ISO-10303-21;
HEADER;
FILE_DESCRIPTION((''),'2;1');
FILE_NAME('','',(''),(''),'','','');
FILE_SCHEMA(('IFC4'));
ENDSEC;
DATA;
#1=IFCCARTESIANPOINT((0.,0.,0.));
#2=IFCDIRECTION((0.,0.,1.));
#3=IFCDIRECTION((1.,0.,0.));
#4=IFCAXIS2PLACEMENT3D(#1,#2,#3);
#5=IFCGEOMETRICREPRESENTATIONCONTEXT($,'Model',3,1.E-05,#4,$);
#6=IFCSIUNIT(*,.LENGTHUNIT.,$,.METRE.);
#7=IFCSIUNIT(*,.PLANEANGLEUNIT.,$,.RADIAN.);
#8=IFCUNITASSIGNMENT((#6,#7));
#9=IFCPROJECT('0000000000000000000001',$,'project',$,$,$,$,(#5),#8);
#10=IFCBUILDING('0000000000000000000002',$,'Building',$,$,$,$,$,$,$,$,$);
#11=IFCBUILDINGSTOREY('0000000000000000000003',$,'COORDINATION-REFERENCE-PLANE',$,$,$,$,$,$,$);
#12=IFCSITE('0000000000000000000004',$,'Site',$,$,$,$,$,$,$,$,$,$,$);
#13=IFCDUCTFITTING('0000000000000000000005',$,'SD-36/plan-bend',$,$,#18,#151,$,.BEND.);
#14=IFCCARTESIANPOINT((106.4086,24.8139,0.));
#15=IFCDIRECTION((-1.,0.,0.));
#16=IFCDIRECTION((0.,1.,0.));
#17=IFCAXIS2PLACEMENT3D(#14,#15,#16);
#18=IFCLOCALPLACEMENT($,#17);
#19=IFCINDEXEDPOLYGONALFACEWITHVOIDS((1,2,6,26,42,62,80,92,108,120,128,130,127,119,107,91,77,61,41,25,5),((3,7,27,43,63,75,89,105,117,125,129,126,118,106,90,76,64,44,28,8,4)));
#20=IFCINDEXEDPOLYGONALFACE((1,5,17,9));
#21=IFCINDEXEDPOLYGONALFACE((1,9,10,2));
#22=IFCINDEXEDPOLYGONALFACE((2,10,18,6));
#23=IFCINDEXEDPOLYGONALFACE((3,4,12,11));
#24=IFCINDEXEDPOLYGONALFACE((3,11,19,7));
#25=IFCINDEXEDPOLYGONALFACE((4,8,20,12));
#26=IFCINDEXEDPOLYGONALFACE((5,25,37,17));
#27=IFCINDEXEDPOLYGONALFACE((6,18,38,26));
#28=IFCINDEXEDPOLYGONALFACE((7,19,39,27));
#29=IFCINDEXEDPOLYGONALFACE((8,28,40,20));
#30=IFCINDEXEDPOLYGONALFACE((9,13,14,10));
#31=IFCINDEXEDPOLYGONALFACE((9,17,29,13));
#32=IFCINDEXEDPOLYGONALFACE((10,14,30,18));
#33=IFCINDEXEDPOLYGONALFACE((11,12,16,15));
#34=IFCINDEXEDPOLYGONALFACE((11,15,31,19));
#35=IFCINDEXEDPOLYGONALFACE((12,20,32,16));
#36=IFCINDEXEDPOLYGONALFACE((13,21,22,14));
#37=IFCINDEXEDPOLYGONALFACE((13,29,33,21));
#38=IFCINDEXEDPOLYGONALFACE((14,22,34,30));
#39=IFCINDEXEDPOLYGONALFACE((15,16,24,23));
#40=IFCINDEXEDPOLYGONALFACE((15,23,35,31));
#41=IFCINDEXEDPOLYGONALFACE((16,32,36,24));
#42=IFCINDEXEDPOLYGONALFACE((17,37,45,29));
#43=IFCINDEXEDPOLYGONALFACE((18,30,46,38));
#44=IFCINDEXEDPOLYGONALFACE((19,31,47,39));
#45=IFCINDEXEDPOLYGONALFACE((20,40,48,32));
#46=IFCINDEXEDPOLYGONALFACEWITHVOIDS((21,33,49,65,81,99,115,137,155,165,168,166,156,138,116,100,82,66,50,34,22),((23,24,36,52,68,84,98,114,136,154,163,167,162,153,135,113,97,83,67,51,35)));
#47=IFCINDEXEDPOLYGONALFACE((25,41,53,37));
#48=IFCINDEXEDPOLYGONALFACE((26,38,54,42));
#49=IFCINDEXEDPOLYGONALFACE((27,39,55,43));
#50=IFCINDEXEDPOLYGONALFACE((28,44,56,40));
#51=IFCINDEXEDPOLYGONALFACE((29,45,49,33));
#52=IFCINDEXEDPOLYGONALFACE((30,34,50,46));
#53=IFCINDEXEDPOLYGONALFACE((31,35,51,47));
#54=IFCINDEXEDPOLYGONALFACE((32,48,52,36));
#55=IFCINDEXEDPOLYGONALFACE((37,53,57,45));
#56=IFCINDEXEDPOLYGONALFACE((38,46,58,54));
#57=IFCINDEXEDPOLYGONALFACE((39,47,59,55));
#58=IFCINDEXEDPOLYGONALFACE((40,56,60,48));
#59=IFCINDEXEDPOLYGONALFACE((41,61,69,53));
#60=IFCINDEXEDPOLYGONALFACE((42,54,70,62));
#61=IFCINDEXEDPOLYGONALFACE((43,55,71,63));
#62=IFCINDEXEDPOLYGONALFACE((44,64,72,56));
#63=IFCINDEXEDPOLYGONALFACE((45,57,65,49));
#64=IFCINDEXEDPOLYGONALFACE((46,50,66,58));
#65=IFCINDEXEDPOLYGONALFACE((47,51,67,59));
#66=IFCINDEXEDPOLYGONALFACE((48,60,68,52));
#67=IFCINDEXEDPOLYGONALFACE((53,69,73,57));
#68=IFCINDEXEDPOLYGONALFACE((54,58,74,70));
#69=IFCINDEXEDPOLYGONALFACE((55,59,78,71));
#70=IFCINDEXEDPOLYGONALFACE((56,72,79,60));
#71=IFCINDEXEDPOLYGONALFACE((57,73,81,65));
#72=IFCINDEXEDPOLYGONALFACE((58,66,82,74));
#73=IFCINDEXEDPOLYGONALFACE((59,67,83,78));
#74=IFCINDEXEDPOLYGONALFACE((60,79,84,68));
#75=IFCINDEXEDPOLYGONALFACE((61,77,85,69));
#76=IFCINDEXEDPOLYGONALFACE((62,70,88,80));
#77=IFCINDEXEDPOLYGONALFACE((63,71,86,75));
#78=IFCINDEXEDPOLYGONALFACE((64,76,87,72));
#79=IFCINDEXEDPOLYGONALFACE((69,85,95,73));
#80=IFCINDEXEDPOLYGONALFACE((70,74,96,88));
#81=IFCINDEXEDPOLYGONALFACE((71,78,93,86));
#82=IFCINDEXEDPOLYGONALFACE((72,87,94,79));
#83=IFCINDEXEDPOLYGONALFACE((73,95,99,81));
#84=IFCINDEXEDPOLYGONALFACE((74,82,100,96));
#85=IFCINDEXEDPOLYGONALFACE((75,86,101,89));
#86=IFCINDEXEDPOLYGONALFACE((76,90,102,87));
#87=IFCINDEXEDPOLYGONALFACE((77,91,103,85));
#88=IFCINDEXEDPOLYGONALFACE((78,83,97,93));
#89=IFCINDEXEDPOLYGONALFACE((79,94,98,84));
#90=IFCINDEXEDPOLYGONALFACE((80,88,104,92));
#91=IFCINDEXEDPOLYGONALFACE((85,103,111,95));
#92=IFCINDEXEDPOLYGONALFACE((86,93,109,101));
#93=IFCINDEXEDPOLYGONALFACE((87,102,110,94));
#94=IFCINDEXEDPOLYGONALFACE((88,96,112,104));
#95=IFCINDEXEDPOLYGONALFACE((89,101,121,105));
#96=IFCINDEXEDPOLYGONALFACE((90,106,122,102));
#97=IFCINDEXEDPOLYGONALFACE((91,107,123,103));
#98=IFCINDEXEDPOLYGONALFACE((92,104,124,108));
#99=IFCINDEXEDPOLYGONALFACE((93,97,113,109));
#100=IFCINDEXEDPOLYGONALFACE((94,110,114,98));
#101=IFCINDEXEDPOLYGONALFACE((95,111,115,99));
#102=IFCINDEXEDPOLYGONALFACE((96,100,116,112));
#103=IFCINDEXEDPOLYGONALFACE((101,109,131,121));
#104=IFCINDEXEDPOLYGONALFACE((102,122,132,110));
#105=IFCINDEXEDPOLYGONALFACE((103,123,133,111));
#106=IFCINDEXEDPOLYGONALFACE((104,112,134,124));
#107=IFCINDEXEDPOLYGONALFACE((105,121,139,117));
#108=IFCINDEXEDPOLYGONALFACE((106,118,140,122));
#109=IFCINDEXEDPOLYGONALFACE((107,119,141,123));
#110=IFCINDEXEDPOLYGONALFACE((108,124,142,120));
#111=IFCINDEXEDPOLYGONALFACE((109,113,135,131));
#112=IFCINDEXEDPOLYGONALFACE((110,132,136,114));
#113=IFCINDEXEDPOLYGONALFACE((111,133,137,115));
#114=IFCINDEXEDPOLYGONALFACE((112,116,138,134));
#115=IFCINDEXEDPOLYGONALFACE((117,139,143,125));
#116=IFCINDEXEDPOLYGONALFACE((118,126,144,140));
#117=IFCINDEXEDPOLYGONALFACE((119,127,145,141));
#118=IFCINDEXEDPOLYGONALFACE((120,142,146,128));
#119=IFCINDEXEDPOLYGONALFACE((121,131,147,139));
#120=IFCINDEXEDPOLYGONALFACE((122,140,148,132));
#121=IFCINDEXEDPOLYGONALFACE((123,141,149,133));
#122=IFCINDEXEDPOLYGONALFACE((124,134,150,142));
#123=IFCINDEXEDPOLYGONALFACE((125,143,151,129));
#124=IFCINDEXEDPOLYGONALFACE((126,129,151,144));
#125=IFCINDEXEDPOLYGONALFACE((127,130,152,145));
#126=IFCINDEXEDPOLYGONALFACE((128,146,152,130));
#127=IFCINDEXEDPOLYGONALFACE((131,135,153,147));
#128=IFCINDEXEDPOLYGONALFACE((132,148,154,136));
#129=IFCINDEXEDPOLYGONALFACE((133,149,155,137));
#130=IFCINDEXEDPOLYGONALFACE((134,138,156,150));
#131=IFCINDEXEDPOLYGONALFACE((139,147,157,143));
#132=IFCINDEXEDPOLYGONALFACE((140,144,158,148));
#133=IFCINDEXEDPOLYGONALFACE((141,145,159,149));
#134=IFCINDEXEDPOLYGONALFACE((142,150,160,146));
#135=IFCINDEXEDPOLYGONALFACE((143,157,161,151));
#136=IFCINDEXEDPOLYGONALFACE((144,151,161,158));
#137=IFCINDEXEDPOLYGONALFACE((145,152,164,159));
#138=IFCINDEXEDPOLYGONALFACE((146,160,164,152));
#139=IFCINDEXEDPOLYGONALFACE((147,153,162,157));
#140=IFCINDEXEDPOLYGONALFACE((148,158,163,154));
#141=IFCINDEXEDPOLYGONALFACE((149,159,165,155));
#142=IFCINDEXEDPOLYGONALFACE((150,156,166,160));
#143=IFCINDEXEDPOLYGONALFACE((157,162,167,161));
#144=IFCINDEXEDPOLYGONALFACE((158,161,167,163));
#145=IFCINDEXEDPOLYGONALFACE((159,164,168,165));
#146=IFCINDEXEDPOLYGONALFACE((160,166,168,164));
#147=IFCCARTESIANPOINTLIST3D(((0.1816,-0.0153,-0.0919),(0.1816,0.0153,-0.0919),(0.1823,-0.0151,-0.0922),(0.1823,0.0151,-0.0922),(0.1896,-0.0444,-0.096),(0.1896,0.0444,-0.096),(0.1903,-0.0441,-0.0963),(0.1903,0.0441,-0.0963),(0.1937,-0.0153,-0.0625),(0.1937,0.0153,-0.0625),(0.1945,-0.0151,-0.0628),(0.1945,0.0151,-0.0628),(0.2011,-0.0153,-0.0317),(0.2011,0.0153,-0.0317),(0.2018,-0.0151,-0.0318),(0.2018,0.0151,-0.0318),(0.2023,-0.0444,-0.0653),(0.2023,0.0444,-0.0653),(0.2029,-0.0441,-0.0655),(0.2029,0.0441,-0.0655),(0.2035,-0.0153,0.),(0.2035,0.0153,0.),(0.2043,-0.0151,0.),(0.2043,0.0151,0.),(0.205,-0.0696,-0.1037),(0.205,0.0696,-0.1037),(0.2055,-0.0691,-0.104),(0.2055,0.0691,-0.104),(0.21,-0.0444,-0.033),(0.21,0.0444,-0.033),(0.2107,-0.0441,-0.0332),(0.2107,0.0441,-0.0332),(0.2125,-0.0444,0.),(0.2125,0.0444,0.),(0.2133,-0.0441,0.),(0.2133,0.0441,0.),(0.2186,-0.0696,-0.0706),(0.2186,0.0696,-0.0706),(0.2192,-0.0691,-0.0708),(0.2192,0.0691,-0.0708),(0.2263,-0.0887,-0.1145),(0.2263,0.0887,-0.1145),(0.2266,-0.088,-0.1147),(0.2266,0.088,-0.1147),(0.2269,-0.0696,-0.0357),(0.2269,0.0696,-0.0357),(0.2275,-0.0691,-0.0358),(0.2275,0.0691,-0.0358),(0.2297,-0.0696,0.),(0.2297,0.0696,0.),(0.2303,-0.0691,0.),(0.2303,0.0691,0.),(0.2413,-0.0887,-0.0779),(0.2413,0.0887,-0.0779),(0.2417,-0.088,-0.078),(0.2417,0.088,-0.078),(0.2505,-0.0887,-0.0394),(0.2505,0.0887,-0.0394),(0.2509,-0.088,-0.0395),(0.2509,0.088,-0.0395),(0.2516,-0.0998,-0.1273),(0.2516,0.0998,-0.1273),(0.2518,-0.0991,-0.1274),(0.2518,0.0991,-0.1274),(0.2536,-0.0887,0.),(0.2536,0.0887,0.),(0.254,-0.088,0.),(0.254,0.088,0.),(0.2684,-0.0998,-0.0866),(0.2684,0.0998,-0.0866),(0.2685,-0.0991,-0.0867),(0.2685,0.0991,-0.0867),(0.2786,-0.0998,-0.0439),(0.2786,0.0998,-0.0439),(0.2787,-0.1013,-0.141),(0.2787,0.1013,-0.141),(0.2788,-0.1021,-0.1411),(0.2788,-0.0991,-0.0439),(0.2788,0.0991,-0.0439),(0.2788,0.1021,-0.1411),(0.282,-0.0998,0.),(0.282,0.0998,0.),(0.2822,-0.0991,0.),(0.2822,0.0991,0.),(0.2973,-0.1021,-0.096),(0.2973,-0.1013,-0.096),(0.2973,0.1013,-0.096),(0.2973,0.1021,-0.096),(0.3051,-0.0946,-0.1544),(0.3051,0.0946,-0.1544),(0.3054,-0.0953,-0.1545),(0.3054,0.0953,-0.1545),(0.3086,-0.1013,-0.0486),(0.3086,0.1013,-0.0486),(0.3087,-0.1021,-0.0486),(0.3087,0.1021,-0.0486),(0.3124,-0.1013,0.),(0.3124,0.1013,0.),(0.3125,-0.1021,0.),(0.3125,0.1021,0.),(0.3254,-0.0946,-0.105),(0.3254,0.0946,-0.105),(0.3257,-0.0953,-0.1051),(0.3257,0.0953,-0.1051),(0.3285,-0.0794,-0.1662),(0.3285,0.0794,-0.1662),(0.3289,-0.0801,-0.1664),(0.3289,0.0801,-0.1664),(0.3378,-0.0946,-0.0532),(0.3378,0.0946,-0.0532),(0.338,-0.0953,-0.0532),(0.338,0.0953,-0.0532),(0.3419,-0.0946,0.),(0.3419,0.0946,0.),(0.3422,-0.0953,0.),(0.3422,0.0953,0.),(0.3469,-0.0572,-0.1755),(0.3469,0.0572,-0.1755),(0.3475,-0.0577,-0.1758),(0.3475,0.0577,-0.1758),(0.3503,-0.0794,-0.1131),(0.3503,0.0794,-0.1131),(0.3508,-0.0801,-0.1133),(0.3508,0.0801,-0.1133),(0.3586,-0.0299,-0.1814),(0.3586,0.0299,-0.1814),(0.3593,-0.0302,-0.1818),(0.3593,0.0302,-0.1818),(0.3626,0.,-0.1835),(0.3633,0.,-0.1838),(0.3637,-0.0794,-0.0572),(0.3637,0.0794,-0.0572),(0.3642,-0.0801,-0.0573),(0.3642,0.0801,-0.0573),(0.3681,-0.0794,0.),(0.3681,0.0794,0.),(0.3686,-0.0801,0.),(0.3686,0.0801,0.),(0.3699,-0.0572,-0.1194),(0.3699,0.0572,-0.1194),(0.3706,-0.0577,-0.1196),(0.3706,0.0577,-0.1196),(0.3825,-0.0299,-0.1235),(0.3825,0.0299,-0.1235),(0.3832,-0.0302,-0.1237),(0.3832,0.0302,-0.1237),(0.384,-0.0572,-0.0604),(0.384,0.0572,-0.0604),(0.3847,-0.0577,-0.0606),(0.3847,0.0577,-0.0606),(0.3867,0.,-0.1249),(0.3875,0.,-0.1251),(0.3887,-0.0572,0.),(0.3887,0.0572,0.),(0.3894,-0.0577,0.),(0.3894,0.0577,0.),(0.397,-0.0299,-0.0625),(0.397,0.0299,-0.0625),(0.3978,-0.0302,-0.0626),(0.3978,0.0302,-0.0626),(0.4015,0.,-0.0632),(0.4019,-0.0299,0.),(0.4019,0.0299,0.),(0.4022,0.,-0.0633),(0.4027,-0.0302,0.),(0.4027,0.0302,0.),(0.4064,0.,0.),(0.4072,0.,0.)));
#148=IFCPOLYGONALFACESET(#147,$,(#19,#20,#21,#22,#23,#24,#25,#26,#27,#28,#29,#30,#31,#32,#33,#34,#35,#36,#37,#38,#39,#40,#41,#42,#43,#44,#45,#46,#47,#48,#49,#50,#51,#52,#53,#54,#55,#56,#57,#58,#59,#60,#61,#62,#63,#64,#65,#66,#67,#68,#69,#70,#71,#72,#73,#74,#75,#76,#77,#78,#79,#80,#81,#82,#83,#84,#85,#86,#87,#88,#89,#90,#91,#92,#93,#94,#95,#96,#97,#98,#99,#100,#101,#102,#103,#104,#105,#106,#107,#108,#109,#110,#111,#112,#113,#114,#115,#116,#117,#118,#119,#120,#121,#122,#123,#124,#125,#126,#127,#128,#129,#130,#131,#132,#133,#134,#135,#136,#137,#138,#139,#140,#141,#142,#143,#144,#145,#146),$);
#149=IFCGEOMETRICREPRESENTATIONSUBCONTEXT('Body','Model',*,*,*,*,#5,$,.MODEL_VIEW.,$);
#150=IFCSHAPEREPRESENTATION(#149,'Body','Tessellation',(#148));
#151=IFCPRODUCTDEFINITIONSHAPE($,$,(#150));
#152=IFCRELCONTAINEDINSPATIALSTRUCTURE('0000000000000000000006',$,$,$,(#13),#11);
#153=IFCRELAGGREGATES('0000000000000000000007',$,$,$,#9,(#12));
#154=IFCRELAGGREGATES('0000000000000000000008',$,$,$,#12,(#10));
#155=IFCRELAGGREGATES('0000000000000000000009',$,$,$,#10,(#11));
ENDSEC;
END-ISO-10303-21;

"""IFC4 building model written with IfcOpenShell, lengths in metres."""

from ifc_helpers import new_model, entity, si_unit, frame, origin_with_axes, place, context, subcontext, project, spatial, element, save


model = new_model("IFC4")

# Units and contexts
model_context = context("Model", 3, precision=1e-05, world=origin_with_axes())
body_context_1 = subcontext(model_context, "Body", "Model", "MODEL_VIEW")
ifc_project = project(units=[si_unit("LENGTHUNIT", "METRE"), si_unit("PLANEANGLEUNIT", "RADIAN")], contexts=[model_context])

# Site, building, storey
site = spatial("IfcSite", under=ifc_project, Name="Site")
building = spatial("IfcBuilding", under=site, Name="Building")
storey = spatial("IfcBuildingStorey", under=building, Name="COORDINATION-REFERENCE-PLANE")

# Duct fitting
duct_fitting_1_placement = place(None, frame((106.4086, 24.8139, 0.0), z_axis=(-1.0, 0.0, 0.0), x_axis=(0.0, 1.0, 0.0)))
element("IfcDuctFitting", 1, at=duct_fitting_1_placement, inside=storey, Name="SD-36/plan-bend", PredefinedType="BEND", context=body_context_1, shape_type="SweptSolid", body=[
    entity("IfcRevolvedAreaSolid", entity("IfcCircleHollowProfileDef", "AREA", None, entity("IfcAxis2Placement2D", entity("IfcCartesianPoint", [0.3048, 0.0])), 0.1024, 0.0008), entity("IfcAxis2Placement3D", entity("IfcCartesianPoint", [0.0, 0.0, 0.0]), entity("IfcDirection", [0.0, 0.0, 1.0]), entity("IfcDirection", [1.0, 0.0, 0.0])), entity("IfcAxis1Placement", entity("IfcCartesianPoint", [0.0, 0.0, 0.0]), entity("IfcDirection", [0.0, 1.0, 0.0])), 0.468399),
])

save(model, "model.ifc")
